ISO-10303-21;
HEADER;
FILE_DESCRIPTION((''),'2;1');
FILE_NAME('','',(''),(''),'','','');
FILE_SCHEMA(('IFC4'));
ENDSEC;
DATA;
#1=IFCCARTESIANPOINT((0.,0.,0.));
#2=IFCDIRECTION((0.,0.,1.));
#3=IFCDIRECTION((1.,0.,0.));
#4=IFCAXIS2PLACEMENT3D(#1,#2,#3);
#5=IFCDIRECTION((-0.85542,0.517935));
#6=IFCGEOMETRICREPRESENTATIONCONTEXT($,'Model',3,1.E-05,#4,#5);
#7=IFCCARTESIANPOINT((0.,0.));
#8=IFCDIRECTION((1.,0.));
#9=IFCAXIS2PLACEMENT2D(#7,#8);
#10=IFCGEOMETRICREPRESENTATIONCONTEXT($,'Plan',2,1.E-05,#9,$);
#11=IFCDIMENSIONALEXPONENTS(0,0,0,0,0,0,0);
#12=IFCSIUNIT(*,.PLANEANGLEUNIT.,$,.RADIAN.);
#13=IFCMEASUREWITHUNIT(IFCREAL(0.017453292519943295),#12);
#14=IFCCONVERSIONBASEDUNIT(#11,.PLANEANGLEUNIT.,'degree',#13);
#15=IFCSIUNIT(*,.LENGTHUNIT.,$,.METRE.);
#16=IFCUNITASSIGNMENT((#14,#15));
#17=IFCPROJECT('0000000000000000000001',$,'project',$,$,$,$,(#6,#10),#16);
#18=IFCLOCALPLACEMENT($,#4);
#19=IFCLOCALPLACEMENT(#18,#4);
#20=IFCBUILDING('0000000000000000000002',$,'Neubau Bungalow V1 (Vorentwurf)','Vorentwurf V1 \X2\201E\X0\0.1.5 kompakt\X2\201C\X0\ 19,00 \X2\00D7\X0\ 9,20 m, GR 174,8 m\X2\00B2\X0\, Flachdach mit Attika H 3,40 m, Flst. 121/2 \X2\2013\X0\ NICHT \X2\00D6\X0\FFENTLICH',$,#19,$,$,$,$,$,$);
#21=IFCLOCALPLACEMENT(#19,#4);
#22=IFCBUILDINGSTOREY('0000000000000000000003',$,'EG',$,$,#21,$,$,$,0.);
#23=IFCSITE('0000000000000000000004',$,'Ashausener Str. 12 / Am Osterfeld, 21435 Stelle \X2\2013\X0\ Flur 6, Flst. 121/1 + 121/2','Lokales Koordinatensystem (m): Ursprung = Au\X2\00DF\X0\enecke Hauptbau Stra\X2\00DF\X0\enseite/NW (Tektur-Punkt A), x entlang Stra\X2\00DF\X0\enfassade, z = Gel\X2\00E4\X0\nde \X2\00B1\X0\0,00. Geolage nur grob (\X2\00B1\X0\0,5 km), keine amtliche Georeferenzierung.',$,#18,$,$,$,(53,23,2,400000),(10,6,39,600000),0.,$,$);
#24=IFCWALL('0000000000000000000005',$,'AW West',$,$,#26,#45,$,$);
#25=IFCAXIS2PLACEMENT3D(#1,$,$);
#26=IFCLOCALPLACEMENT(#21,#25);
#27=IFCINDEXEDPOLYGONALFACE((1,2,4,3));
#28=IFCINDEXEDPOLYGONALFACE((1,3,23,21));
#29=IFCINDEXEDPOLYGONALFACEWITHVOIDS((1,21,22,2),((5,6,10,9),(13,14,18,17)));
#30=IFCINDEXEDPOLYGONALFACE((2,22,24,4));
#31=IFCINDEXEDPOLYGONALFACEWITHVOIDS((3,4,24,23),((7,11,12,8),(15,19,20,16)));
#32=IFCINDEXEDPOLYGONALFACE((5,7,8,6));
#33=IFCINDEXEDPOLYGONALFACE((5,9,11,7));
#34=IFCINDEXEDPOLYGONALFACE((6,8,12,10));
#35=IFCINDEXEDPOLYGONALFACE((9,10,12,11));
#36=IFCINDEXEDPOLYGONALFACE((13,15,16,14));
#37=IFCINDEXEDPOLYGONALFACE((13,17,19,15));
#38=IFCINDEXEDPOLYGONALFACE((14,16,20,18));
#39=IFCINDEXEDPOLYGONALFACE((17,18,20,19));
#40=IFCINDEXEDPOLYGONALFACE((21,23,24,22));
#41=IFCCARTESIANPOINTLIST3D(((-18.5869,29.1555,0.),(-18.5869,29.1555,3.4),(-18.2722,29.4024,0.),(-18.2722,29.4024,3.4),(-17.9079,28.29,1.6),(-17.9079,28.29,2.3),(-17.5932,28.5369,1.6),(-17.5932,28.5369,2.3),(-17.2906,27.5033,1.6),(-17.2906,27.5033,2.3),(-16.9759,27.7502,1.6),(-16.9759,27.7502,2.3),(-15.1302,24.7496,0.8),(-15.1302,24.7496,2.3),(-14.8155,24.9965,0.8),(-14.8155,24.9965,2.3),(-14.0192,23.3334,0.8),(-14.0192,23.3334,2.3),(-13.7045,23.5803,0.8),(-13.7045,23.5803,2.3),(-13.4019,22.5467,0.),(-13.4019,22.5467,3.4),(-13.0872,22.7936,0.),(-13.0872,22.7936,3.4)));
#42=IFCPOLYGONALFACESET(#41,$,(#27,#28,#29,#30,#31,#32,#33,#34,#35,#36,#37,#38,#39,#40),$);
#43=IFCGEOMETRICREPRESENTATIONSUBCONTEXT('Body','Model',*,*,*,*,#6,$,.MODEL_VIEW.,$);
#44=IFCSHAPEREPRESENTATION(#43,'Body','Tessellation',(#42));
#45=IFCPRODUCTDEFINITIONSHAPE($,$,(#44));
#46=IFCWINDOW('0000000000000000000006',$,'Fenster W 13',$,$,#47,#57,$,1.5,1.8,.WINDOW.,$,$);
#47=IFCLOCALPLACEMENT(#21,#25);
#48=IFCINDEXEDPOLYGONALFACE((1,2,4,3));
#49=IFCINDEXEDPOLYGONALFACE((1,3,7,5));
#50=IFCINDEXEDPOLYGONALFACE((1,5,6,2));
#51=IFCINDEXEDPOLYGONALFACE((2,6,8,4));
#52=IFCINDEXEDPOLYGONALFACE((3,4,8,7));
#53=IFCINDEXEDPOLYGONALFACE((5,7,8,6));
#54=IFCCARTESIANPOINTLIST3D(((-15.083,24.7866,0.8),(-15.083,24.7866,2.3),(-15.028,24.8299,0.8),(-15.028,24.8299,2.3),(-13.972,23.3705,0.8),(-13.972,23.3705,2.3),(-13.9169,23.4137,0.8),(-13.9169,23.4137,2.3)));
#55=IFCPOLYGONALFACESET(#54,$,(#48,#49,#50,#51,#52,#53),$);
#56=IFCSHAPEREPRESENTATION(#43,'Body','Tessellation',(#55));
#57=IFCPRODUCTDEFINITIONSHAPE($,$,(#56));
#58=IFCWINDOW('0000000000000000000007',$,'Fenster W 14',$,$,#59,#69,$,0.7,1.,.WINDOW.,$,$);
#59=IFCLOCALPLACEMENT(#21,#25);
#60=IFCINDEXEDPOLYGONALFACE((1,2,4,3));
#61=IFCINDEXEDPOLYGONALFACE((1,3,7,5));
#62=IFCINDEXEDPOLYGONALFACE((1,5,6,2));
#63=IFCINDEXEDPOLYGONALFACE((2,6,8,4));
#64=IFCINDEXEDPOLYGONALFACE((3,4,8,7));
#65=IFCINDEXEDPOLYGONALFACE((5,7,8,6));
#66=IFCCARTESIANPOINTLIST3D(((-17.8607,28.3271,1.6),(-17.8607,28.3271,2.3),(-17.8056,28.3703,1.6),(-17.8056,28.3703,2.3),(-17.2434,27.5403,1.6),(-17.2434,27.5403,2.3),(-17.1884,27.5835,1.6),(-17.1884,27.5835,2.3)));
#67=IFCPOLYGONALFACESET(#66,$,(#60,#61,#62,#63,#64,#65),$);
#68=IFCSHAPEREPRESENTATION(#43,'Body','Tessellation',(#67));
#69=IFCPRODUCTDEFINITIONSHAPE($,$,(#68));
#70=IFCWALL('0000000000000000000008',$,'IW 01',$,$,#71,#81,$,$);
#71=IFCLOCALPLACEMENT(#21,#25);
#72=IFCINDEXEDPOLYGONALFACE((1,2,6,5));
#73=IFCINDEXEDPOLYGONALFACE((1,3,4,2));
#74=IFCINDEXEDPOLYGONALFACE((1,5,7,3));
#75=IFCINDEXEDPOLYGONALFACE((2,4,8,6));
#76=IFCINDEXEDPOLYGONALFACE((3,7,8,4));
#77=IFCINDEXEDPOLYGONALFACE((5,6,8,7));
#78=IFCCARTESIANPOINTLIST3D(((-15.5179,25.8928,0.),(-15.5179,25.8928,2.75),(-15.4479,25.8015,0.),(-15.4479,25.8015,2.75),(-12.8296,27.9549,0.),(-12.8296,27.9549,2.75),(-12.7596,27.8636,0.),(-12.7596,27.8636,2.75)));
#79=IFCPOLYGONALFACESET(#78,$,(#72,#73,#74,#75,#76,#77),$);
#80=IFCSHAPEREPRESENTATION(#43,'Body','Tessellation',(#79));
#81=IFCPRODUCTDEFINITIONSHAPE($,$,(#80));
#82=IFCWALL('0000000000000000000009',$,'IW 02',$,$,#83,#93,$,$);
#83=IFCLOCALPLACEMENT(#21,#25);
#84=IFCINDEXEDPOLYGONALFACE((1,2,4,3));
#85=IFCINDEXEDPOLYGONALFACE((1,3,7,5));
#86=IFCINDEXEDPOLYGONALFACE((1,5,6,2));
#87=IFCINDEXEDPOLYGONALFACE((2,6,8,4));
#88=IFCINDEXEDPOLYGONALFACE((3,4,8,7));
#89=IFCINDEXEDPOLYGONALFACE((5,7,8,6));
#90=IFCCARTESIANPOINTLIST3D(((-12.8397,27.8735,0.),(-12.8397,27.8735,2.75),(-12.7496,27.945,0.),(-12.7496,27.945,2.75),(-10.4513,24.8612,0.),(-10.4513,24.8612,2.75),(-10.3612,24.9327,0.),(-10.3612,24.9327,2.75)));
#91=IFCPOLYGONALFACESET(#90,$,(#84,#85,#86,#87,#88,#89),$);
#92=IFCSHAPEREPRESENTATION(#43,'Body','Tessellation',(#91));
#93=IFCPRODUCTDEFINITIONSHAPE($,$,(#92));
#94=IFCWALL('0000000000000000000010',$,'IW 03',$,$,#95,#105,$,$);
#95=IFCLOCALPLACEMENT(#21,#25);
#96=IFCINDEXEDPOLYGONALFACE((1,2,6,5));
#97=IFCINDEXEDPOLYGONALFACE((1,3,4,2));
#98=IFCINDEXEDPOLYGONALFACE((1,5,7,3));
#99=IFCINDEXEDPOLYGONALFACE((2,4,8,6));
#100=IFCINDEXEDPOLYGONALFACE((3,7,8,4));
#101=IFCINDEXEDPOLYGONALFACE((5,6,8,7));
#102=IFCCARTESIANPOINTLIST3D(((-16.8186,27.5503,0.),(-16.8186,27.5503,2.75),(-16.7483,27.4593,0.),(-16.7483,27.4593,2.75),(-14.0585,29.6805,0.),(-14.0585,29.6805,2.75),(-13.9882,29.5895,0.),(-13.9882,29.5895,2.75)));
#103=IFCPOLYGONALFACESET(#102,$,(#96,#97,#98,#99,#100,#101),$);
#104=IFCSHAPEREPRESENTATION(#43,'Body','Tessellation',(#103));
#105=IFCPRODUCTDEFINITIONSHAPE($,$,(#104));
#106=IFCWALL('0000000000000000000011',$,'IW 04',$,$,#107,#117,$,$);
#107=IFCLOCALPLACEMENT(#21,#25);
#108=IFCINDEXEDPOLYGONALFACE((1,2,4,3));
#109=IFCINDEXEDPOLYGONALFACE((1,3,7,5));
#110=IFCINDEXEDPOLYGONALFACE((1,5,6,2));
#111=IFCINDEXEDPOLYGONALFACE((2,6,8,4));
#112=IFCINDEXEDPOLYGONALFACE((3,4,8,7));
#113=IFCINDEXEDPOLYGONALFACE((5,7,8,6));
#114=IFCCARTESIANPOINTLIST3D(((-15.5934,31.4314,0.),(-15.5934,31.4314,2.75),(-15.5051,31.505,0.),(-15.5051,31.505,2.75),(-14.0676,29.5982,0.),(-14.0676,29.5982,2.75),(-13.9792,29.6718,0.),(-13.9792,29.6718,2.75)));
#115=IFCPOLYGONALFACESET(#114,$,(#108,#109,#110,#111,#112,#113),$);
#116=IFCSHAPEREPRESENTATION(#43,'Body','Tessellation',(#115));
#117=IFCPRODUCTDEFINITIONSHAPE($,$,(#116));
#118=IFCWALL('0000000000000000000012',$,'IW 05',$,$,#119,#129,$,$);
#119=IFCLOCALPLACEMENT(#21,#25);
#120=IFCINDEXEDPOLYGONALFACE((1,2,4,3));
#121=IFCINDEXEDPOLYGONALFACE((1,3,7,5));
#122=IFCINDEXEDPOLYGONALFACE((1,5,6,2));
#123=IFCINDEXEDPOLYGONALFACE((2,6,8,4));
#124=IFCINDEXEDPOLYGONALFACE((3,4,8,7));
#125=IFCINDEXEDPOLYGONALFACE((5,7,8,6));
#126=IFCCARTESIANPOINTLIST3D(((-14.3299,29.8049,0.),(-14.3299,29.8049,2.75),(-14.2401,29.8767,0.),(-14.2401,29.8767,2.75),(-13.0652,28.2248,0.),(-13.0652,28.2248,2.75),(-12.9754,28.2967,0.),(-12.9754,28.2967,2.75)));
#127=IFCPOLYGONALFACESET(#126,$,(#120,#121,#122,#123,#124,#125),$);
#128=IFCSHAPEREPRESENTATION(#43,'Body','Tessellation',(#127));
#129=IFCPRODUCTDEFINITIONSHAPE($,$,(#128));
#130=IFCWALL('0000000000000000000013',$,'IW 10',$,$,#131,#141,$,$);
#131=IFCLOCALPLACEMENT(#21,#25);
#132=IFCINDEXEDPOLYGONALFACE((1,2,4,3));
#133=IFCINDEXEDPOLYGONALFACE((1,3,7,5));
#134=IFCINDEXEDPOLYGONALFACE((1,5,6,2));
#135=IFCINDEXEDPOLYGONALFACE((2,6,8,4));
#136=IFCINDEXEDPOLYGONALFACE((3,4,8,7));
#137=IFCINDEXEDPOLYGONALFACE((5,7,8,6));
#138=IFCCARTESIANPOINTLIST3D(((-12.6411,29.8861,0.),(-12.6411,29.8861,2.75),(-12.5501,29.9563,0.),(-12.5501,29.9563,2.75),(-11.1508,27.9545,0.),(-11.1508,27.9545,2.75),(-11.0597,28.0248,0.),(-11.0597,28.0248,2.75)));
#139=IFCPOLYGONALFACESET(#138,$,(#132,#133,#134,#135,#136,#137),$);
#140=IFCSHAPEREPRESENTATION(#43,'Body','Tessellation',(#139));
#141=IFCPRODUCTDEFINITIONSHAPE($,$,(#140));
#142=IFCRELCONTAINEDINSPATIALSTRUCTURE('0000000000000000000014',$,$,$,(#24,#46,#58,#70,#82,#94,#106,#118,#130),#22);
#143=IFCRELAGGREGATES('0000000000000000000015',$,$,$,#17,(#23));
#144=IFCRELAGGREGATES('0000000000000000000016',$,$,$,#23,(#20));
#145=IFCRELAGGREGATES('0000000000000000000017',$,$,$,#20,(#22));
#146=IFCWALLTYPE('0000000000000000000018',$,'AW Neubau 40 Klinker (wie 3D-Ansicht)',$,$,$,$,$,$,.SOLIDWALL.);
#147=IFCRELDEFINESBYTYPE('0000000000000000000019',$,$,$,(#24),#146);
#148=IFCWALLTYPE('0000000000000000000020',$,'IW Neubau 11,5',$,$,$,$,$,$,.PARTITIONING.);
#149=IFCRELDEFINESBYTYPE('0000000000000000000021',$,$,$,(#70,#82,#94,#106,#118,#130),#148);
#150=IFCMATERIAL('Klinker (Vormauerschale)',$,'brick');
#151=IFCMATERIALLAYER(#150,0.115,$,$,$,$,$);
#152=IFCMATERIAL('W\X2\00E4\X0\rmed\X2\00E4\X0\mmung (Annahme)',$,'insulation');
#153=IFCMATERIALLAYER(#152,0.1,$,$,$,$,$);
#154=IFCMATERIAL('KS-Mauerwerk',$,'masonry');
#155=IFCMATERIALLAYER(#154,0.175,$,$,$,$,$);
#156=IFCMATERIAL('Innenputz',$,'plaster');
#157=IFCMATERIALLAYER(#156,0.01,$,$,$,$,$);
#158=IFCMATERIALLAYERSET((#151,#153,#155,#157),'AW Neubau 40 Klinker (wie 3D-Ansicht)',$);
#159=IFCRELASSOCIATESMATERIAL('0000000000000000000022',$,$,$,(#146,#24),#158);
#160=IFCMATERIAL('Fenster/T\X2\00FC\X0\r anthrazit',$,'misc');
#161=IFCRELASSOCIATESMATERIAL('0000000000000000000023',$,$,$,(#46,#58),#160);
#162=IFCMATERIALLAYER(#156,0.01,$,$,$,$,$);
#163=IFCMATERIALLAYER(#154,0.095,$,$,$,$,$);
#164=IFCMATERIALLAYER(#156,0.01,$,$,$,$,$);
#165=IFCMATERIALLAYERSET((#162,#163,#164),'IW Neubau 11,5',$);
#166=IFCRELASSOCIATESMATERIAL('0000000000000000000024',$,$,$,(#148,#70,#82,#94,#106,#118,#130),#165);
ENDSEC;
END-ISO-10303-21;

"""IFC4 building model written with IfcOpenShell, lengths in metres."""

from ifc_helpers import new_model, entity, si_unit, converted_unit, direction, frame, origin_with_axes, origin_2d_with_axis, place, context, subcontext, project, spatial, indexed_curve, outline, extrude, material, layer, layer_set, layer_usage, type_object, element, fill, save


model = new_model("IFC4")

# Units and contexts
model_context = context("Model", 3, precision=1e-05, world=origin_with_axes(), true_north=direction((-0.85542, 0.517935)))
plan_context = context("Plan", 2, precision=1e-05, world=origin_2d_with_axis())
body_context = subcontext(model_context, "Body", "Model", "MODEL_VIEW")
ifc_project = project(units=[converted_unit("PLANEANGLEUNIT", "degree", entity("IfcReal", 0.017453292519943295), si_unit("PLANEANGLEUNIT", "RADIAN"), dimensions=[0, 0, 0, 0, 0, 0, 0]), si_unit("LENGTHUNIT", "METRE")], contexts=[model_context, plan_context])

# Site, building, storey
site_placement = place(None, origin_with_axes())
site = spatial("IfcSite", under=ifc_project, at=site_placement, Name="Ashausener Str. 12 / Am Osterfeld, 21435 Stelle – Flur 6, Flst. 121/1 + 121/2", Description="Lokales Koordinatensystem (m): Ursprung = Außenecke Hauptbau Straßenseite/NW (Tektur-Punkt A), x entlang Straßenfassade, z = Gelände ±0,00. Geolage nur grob (±0,5 km), keine amtliche Georeferenzierung.", RefLatitude=(53, 23, 2, 400000), RefLongitude=(10, 6, 39, 600000), RefElevation=0.0)
building_placement = place(site_placement, origin_with_axes())
building = spatial("IfcBuilding", under=site, at=building_placement, Name="Neubau Bungalow V1 (Vorentwurf)", Description="Vorentwurf V1 „0.1.5 kompakt“ 19,00 × 9,20 m, GR 174,8 m², Flachdach mit Attika H 3,40 m, Flst. 121/2 – NICHT ÖFFENTLICH")
storey_placement = place(building_placement, origin_with_axes())
storey = spatial("IfcBuildingStorey", under=building, at=storey_placement, Name="EG", Elevation=0.0)

# Wall, openings, windows
ifc_material_1 = material(Name="Klinker (Vormauerschale)", Category="brick")
ifc_layer_1 = layer(ifc_material_1, 0.115)
ifc_material_2 = material(Name="Wärmedämmung (Annahme)", Category="insulation")
ifc_layer_2 = layer(ifc_material_2, 0.1)
ifc_material_3 = material(Name="KS-Mauerwerk", Category="masonry")
ifc_layer_3 = layer(ifc_material_3, 0.175)
ifc_material_4 = material(Name="Innenputz", Category="plaster")
ifc_layer_4 = layer(ifc_material_4, 0.01)
ifc_layer_set_1 = layer_set([ifc_layer_1, ifc_layer_2, ifc_layer_3, ifc_layer_4], Name="AW Neubau 40 Klinker (wie 3D-Ansicht)")
wall_type_1 = type_object("IfcWallType", Name="AW Neubau 40 Klinker (wie 3D-Ansicht)", PredefinedType="SOLIDWALL", material=ifc_layer_set_1)
ifc_material_5 = material(Name="Fenster/Tür anthrazit", Category="misc")
ifc_layer_usage_1 = layer_usage(ifc_layer_set_1, "AXIS2", "POSITIVE", 0.0)
wall_1_placement = place(storey_placement, frame((-18.5869, 29.1555, 0.0), z_axis=(0.0, 0.0, 1.0), x_axis=(0.617258, -0.786761, 0.0)))
wall_1 = element("IfcWall", 1, at=wall_1_placement, inside=storey, type_object=wall_type_1, material=ifc_layer_usage_1, Name="AW West", context=body_context, shape_type="SweptSolid", body=[
    extrude(outline(indexed_curve([(0.0, 0.0), (0.0, 0.4), (8.4, 0.4), (8.4, 0.0), (0.0, 0.0)], self_intersect=False)), origin_with_axes(), (0.0, 0.0, 1.0), 3.4),
])
opening_1_placement = place(wall_1_placement, frame((5.6, -0.1, 0.8), z_axis=(0.0, 0.0, 1.0), x_axis=(1.0, 0.0, 0.0)))
opening_1 = element("IfcOpeningElement", 2, at=opening_1_placement, cuts=wall_1, context=body_context, shape_type="SweptSolid", body=[
    extrude(outline(indexed_curve([(0.0, 0.0), (0.0, 0.6), (1.8, 0.6), (1.8, 0.0), (0.0, 0.0)], self_intersect=False)), origin_with_axes(), (0.0, 0.0, 1.0), 1.5),
])
opening_2_placement = place(wall_1_placement, frame((1.1, -0.1, 1.6), z_axis=(0.0, 0.0, 1.0), x_axis=(1.0, 0.0, 0.0)))
opening_2 = element("IfcOpeningElement", 3, at=opening_2_placement, cuts=wall_1, context=body_context, shape_type="SweptSolid", body=[
    extrude(outline(indexed_curve([(0.0, 0.0), (0.0, 0.6), (1.0, 0.6), (1.0, 0.0), (0.0, 0.0)], self_intersect=False)), origin_with_axes(), (0.0, 0.0, 1.0), 0.7),
])
window_1_placement = place(storey_placement, frame((-15.083, 24.7866, 0.8), z_axis=(0.0, 0.0, 1.0), x_axis=(0.617258, -0.786761, 0.0)))
window_1 = element("IfcWindow", 4, at=window_1_placement, inside=storey, material=ifc_material_5, Name="Fenster W 13", OverallHeight=1.5, OverallWidth=1.8, PredefinedType="WINDOW", context=body_context, shape_type="SweptSolid", body=[
    extrude(outline(indexed_curve([(0.0, 0.0), (0.0, 0.07), (1.8, 0.07), (1.8, 0.0), (0.0, 0.0)], self_intersect=False)), origin_with_axes(), (0.0, 0.0, 1.0), 1.5),
])
fill(opening_1, window_1)
window_2_placement = place(storey_placement, frame((-17.8607, 28.3271, 1.6), z_axis=(0.0, 0.0, 1.0), x_axis=(0.617258, -0.786761, 0.0)))
window_2 = element("IfcWindow", 5, at=window_2_placement, inside=storey, material=ifc_material_5, Name="Fenster W 14", OverallHeight=0.7, OverallWidth=1.0, PredefinedType="WINDOW", context=body_context, shape_type="SweptSolid", body=[
    extrude(outline(indexed_curve([(0.0, 0.0), (0.0, 0.07), (1.0, 0.07), (1.0, 0.0), (0.0, 0.0)], self_intersect=False)), origin_with_axes(), (0.0, 0.0, 1.0), 0.7),
])
fill(opening_2, window_2)

# Walls
ifc_layer_5 = layer(ifc_material_4, 0.01)
ifc_layer_6 = layer(ifc_material_3, 0.095)
ifc_layer_7 = layer(ifc_material_4, 0.01)
ifc_layer_set_2 = layer_set([ifc_layer_5, ifc_layer_6, ifc_layer_7], Name="IW Neubau 11,5")
ifc_layer_usage_2 = layer_usage(ifc_layer_set_2, "AXIS2", "POSITIVE", -0.0575)
wall_type_2 = type_object("IfcWallType", Name="IW Neubau 11,5", PredefinedType="PARTITIONING", material=ifc_layer_set_2)
wall_2_placement = place(storey_placement, frame((-15.4829, 25.8471, 0.0), z_axis=(0.0, 0.0, 1.0), x_axis=(0.793448, 0.608638, 0.0)))
element("IfcWall", 6, at=wall_2_placement, inside=storey, type_object=wall_type_2, material=ifc_layer_usage_2, Name="IW 01", context=body_context, shape_type="SweptSolid", body=[
    extrude(outline(indexed_curve([(0.0, 0.0), (0.0, 0.115), (3.3881, 0.115), (3.3881, 0.0), (0.0, 0.0)], self_intersect=False)), frame((0.0, -0.0575, 0.0), z_axis=(0.0, 0.0, 1.0), x_axis=(1.0, 0.0, 0.0)), (0.0, 0.0, 1.0), 2.75),
])
ifc_layer_usage_3 = layer_usage(ifc_layer_set_2, "AXIS2", "POSITIVE", -0.0575)
wall_3_placement = place(storey_placement, frame((-12.7946, 27.9093, 0.0), z_axis=(0.0, 0.0, 1.0), x_axis=(0.621281, -0.783588, 0.0)))
element("IfcWall", 7, at=wall_3_placement, inside=storey, type_object=wall_type_2, material=ifc_layer_usage_3, Name="IW 02", context=body_context, shape_type="SweptSolid", body=[
    extrude(outline(indexed_curve([(0.0, 0.0), (0.0, 0.115), (3.8443, 0.115), (3.8443, 0.0), (0.0, 0.0)], self_intersect=False)), frame((0.0, -0.0575, 0.0), z_axis=(0.0, 0.0, 1.0), x_axis=(1.0, 0.0, 0.0)), (0.0, 0.0, 1.0), 2.75),
])
ifc_layer_usage_4 = layer_usage(ifc_layer_set_2, "AXIS2", "POSITIVE", -0.0575)
wall_4_placement = place(storey_placement, frame((-16.7834, 27.5048, 0.0), z_axis=(0.0, 0.0, 1.0), x_axis=(0.791644, 0.610982, 0.0)))
element("IfcWall", 8, at=wall_4_placement, inside=storey, type_object=wall_type_2, material=ifc_layer_usage_4, Name="IW 03", context=body_context, shape_type="SweptSolid", body=[
    extrude(outline(indexed_curve([(0.0, 0.0), (0.0, 0.115), (3.4865, 0.115), (3.4865, 0.0), (0.0, 0.0)], self_intersect=False)), frame((0.0, -0.0575, 0.0), z_axis=(0.0, 0.0, 1.0), x_axis=(1.0, 0.0, 0.0)), (0.0, 0.0, 1.0), 2.75),
])
ifc_layer_usage_5 = layer_usage(ifc_layer_set_2, "AXIS2", "POSITIVE", -0.0575)
wall_5_placement = place(storey_placement, frame((-14.0234, 29.635, 0.0), z_axis=(0.0, 0.0, 1.0), x_axis=(-0.63974, 0.768591, 0.0)))
element("IfcWall", 9, at=wall_5_placement, inside=storey, type_object=wall_type_2, material=ifc_layer_usage_5, Name="IW 04", context=body_context, shape_type="SweptSolid", body=[
    extrude(outline(indexed_curve([(0.0, 0.0), (0.0, 0.115), (2.3852, 0.115), (2.3852, 0.0), (0.0, 0.0)], self_intersect=False)), frame((0.0, -0.0575, 0.0), z_axis=(0.0, 0.0, 1.0), x_axis=(1.0, 0.0, 0.0)), (0.0, 0.0, 1.0), 2.75),
])
ifc_layer_usage_6 = layer_usage(ifc_layer_set_2, "AXIS2", "POSITIVE", -0.0575)
wall_6_placement = place(storey_placement, frame((-14.285, 29.8408, 0.0), z_axis=(0.0, 0.0, 1.0), x_axis=(0.624886, -0.780716, 0.0)))
element("IfcWall", 10, at=wall_6_placement, inside=storey, type_object=wall_type_2, material=ifc_layer_usage_6, Name="IW 05", context=body_context, shape_type="SweptSolid", body=[
    extrude(outline(indexed_curve([(0.0, 0.0), (0.0, 0.115), (2.0239, 0.115), (2.0239, 0.0), (0.0, 0.0)], self_intersect=False)), frame((0.0, -0.0575, 0.0), z_axis=(0.0, 0.0, 1.0), x_axis=(1.0, 0.0, 0.0)), (0.0, 0.0, 1.0), 2.75),
])
ifc_layer_usage_7 = layer_usage(ifc_layer_set_2, "AXIS2", "POSITIVE", -0.0575)
wall_7_placement = place(storey_placement, frame((-12.5956, 29.9212, 0.0), z_axis=(0.0, 0.0, 1.0), x_axis=(0.610886, -0.791719, 0.0)))
element("IfcWall", 11, at=wall_7_placement, inside=storey, type_object=wall_type_2, material=ifc_layer_usage_7, Name="IW 10", context=body_context, shape_type="SweptSolid", body=[
    extrude(outline(indexed_curve([(0.0, 0.0), (0.0, 0.115), (2.4397, 0.115), (2.4397, 0.0), (0.0, 0.0)], self_intersect=False)), frame((0.0, -0.0575, 0.0), z_axis=(0.0, 0.0, 1.0), x_axis=(1.0, 0.0, 0.0)), (0.0, 0.0, 1.0), 2.75),
])

save(model, "model.ifc")
